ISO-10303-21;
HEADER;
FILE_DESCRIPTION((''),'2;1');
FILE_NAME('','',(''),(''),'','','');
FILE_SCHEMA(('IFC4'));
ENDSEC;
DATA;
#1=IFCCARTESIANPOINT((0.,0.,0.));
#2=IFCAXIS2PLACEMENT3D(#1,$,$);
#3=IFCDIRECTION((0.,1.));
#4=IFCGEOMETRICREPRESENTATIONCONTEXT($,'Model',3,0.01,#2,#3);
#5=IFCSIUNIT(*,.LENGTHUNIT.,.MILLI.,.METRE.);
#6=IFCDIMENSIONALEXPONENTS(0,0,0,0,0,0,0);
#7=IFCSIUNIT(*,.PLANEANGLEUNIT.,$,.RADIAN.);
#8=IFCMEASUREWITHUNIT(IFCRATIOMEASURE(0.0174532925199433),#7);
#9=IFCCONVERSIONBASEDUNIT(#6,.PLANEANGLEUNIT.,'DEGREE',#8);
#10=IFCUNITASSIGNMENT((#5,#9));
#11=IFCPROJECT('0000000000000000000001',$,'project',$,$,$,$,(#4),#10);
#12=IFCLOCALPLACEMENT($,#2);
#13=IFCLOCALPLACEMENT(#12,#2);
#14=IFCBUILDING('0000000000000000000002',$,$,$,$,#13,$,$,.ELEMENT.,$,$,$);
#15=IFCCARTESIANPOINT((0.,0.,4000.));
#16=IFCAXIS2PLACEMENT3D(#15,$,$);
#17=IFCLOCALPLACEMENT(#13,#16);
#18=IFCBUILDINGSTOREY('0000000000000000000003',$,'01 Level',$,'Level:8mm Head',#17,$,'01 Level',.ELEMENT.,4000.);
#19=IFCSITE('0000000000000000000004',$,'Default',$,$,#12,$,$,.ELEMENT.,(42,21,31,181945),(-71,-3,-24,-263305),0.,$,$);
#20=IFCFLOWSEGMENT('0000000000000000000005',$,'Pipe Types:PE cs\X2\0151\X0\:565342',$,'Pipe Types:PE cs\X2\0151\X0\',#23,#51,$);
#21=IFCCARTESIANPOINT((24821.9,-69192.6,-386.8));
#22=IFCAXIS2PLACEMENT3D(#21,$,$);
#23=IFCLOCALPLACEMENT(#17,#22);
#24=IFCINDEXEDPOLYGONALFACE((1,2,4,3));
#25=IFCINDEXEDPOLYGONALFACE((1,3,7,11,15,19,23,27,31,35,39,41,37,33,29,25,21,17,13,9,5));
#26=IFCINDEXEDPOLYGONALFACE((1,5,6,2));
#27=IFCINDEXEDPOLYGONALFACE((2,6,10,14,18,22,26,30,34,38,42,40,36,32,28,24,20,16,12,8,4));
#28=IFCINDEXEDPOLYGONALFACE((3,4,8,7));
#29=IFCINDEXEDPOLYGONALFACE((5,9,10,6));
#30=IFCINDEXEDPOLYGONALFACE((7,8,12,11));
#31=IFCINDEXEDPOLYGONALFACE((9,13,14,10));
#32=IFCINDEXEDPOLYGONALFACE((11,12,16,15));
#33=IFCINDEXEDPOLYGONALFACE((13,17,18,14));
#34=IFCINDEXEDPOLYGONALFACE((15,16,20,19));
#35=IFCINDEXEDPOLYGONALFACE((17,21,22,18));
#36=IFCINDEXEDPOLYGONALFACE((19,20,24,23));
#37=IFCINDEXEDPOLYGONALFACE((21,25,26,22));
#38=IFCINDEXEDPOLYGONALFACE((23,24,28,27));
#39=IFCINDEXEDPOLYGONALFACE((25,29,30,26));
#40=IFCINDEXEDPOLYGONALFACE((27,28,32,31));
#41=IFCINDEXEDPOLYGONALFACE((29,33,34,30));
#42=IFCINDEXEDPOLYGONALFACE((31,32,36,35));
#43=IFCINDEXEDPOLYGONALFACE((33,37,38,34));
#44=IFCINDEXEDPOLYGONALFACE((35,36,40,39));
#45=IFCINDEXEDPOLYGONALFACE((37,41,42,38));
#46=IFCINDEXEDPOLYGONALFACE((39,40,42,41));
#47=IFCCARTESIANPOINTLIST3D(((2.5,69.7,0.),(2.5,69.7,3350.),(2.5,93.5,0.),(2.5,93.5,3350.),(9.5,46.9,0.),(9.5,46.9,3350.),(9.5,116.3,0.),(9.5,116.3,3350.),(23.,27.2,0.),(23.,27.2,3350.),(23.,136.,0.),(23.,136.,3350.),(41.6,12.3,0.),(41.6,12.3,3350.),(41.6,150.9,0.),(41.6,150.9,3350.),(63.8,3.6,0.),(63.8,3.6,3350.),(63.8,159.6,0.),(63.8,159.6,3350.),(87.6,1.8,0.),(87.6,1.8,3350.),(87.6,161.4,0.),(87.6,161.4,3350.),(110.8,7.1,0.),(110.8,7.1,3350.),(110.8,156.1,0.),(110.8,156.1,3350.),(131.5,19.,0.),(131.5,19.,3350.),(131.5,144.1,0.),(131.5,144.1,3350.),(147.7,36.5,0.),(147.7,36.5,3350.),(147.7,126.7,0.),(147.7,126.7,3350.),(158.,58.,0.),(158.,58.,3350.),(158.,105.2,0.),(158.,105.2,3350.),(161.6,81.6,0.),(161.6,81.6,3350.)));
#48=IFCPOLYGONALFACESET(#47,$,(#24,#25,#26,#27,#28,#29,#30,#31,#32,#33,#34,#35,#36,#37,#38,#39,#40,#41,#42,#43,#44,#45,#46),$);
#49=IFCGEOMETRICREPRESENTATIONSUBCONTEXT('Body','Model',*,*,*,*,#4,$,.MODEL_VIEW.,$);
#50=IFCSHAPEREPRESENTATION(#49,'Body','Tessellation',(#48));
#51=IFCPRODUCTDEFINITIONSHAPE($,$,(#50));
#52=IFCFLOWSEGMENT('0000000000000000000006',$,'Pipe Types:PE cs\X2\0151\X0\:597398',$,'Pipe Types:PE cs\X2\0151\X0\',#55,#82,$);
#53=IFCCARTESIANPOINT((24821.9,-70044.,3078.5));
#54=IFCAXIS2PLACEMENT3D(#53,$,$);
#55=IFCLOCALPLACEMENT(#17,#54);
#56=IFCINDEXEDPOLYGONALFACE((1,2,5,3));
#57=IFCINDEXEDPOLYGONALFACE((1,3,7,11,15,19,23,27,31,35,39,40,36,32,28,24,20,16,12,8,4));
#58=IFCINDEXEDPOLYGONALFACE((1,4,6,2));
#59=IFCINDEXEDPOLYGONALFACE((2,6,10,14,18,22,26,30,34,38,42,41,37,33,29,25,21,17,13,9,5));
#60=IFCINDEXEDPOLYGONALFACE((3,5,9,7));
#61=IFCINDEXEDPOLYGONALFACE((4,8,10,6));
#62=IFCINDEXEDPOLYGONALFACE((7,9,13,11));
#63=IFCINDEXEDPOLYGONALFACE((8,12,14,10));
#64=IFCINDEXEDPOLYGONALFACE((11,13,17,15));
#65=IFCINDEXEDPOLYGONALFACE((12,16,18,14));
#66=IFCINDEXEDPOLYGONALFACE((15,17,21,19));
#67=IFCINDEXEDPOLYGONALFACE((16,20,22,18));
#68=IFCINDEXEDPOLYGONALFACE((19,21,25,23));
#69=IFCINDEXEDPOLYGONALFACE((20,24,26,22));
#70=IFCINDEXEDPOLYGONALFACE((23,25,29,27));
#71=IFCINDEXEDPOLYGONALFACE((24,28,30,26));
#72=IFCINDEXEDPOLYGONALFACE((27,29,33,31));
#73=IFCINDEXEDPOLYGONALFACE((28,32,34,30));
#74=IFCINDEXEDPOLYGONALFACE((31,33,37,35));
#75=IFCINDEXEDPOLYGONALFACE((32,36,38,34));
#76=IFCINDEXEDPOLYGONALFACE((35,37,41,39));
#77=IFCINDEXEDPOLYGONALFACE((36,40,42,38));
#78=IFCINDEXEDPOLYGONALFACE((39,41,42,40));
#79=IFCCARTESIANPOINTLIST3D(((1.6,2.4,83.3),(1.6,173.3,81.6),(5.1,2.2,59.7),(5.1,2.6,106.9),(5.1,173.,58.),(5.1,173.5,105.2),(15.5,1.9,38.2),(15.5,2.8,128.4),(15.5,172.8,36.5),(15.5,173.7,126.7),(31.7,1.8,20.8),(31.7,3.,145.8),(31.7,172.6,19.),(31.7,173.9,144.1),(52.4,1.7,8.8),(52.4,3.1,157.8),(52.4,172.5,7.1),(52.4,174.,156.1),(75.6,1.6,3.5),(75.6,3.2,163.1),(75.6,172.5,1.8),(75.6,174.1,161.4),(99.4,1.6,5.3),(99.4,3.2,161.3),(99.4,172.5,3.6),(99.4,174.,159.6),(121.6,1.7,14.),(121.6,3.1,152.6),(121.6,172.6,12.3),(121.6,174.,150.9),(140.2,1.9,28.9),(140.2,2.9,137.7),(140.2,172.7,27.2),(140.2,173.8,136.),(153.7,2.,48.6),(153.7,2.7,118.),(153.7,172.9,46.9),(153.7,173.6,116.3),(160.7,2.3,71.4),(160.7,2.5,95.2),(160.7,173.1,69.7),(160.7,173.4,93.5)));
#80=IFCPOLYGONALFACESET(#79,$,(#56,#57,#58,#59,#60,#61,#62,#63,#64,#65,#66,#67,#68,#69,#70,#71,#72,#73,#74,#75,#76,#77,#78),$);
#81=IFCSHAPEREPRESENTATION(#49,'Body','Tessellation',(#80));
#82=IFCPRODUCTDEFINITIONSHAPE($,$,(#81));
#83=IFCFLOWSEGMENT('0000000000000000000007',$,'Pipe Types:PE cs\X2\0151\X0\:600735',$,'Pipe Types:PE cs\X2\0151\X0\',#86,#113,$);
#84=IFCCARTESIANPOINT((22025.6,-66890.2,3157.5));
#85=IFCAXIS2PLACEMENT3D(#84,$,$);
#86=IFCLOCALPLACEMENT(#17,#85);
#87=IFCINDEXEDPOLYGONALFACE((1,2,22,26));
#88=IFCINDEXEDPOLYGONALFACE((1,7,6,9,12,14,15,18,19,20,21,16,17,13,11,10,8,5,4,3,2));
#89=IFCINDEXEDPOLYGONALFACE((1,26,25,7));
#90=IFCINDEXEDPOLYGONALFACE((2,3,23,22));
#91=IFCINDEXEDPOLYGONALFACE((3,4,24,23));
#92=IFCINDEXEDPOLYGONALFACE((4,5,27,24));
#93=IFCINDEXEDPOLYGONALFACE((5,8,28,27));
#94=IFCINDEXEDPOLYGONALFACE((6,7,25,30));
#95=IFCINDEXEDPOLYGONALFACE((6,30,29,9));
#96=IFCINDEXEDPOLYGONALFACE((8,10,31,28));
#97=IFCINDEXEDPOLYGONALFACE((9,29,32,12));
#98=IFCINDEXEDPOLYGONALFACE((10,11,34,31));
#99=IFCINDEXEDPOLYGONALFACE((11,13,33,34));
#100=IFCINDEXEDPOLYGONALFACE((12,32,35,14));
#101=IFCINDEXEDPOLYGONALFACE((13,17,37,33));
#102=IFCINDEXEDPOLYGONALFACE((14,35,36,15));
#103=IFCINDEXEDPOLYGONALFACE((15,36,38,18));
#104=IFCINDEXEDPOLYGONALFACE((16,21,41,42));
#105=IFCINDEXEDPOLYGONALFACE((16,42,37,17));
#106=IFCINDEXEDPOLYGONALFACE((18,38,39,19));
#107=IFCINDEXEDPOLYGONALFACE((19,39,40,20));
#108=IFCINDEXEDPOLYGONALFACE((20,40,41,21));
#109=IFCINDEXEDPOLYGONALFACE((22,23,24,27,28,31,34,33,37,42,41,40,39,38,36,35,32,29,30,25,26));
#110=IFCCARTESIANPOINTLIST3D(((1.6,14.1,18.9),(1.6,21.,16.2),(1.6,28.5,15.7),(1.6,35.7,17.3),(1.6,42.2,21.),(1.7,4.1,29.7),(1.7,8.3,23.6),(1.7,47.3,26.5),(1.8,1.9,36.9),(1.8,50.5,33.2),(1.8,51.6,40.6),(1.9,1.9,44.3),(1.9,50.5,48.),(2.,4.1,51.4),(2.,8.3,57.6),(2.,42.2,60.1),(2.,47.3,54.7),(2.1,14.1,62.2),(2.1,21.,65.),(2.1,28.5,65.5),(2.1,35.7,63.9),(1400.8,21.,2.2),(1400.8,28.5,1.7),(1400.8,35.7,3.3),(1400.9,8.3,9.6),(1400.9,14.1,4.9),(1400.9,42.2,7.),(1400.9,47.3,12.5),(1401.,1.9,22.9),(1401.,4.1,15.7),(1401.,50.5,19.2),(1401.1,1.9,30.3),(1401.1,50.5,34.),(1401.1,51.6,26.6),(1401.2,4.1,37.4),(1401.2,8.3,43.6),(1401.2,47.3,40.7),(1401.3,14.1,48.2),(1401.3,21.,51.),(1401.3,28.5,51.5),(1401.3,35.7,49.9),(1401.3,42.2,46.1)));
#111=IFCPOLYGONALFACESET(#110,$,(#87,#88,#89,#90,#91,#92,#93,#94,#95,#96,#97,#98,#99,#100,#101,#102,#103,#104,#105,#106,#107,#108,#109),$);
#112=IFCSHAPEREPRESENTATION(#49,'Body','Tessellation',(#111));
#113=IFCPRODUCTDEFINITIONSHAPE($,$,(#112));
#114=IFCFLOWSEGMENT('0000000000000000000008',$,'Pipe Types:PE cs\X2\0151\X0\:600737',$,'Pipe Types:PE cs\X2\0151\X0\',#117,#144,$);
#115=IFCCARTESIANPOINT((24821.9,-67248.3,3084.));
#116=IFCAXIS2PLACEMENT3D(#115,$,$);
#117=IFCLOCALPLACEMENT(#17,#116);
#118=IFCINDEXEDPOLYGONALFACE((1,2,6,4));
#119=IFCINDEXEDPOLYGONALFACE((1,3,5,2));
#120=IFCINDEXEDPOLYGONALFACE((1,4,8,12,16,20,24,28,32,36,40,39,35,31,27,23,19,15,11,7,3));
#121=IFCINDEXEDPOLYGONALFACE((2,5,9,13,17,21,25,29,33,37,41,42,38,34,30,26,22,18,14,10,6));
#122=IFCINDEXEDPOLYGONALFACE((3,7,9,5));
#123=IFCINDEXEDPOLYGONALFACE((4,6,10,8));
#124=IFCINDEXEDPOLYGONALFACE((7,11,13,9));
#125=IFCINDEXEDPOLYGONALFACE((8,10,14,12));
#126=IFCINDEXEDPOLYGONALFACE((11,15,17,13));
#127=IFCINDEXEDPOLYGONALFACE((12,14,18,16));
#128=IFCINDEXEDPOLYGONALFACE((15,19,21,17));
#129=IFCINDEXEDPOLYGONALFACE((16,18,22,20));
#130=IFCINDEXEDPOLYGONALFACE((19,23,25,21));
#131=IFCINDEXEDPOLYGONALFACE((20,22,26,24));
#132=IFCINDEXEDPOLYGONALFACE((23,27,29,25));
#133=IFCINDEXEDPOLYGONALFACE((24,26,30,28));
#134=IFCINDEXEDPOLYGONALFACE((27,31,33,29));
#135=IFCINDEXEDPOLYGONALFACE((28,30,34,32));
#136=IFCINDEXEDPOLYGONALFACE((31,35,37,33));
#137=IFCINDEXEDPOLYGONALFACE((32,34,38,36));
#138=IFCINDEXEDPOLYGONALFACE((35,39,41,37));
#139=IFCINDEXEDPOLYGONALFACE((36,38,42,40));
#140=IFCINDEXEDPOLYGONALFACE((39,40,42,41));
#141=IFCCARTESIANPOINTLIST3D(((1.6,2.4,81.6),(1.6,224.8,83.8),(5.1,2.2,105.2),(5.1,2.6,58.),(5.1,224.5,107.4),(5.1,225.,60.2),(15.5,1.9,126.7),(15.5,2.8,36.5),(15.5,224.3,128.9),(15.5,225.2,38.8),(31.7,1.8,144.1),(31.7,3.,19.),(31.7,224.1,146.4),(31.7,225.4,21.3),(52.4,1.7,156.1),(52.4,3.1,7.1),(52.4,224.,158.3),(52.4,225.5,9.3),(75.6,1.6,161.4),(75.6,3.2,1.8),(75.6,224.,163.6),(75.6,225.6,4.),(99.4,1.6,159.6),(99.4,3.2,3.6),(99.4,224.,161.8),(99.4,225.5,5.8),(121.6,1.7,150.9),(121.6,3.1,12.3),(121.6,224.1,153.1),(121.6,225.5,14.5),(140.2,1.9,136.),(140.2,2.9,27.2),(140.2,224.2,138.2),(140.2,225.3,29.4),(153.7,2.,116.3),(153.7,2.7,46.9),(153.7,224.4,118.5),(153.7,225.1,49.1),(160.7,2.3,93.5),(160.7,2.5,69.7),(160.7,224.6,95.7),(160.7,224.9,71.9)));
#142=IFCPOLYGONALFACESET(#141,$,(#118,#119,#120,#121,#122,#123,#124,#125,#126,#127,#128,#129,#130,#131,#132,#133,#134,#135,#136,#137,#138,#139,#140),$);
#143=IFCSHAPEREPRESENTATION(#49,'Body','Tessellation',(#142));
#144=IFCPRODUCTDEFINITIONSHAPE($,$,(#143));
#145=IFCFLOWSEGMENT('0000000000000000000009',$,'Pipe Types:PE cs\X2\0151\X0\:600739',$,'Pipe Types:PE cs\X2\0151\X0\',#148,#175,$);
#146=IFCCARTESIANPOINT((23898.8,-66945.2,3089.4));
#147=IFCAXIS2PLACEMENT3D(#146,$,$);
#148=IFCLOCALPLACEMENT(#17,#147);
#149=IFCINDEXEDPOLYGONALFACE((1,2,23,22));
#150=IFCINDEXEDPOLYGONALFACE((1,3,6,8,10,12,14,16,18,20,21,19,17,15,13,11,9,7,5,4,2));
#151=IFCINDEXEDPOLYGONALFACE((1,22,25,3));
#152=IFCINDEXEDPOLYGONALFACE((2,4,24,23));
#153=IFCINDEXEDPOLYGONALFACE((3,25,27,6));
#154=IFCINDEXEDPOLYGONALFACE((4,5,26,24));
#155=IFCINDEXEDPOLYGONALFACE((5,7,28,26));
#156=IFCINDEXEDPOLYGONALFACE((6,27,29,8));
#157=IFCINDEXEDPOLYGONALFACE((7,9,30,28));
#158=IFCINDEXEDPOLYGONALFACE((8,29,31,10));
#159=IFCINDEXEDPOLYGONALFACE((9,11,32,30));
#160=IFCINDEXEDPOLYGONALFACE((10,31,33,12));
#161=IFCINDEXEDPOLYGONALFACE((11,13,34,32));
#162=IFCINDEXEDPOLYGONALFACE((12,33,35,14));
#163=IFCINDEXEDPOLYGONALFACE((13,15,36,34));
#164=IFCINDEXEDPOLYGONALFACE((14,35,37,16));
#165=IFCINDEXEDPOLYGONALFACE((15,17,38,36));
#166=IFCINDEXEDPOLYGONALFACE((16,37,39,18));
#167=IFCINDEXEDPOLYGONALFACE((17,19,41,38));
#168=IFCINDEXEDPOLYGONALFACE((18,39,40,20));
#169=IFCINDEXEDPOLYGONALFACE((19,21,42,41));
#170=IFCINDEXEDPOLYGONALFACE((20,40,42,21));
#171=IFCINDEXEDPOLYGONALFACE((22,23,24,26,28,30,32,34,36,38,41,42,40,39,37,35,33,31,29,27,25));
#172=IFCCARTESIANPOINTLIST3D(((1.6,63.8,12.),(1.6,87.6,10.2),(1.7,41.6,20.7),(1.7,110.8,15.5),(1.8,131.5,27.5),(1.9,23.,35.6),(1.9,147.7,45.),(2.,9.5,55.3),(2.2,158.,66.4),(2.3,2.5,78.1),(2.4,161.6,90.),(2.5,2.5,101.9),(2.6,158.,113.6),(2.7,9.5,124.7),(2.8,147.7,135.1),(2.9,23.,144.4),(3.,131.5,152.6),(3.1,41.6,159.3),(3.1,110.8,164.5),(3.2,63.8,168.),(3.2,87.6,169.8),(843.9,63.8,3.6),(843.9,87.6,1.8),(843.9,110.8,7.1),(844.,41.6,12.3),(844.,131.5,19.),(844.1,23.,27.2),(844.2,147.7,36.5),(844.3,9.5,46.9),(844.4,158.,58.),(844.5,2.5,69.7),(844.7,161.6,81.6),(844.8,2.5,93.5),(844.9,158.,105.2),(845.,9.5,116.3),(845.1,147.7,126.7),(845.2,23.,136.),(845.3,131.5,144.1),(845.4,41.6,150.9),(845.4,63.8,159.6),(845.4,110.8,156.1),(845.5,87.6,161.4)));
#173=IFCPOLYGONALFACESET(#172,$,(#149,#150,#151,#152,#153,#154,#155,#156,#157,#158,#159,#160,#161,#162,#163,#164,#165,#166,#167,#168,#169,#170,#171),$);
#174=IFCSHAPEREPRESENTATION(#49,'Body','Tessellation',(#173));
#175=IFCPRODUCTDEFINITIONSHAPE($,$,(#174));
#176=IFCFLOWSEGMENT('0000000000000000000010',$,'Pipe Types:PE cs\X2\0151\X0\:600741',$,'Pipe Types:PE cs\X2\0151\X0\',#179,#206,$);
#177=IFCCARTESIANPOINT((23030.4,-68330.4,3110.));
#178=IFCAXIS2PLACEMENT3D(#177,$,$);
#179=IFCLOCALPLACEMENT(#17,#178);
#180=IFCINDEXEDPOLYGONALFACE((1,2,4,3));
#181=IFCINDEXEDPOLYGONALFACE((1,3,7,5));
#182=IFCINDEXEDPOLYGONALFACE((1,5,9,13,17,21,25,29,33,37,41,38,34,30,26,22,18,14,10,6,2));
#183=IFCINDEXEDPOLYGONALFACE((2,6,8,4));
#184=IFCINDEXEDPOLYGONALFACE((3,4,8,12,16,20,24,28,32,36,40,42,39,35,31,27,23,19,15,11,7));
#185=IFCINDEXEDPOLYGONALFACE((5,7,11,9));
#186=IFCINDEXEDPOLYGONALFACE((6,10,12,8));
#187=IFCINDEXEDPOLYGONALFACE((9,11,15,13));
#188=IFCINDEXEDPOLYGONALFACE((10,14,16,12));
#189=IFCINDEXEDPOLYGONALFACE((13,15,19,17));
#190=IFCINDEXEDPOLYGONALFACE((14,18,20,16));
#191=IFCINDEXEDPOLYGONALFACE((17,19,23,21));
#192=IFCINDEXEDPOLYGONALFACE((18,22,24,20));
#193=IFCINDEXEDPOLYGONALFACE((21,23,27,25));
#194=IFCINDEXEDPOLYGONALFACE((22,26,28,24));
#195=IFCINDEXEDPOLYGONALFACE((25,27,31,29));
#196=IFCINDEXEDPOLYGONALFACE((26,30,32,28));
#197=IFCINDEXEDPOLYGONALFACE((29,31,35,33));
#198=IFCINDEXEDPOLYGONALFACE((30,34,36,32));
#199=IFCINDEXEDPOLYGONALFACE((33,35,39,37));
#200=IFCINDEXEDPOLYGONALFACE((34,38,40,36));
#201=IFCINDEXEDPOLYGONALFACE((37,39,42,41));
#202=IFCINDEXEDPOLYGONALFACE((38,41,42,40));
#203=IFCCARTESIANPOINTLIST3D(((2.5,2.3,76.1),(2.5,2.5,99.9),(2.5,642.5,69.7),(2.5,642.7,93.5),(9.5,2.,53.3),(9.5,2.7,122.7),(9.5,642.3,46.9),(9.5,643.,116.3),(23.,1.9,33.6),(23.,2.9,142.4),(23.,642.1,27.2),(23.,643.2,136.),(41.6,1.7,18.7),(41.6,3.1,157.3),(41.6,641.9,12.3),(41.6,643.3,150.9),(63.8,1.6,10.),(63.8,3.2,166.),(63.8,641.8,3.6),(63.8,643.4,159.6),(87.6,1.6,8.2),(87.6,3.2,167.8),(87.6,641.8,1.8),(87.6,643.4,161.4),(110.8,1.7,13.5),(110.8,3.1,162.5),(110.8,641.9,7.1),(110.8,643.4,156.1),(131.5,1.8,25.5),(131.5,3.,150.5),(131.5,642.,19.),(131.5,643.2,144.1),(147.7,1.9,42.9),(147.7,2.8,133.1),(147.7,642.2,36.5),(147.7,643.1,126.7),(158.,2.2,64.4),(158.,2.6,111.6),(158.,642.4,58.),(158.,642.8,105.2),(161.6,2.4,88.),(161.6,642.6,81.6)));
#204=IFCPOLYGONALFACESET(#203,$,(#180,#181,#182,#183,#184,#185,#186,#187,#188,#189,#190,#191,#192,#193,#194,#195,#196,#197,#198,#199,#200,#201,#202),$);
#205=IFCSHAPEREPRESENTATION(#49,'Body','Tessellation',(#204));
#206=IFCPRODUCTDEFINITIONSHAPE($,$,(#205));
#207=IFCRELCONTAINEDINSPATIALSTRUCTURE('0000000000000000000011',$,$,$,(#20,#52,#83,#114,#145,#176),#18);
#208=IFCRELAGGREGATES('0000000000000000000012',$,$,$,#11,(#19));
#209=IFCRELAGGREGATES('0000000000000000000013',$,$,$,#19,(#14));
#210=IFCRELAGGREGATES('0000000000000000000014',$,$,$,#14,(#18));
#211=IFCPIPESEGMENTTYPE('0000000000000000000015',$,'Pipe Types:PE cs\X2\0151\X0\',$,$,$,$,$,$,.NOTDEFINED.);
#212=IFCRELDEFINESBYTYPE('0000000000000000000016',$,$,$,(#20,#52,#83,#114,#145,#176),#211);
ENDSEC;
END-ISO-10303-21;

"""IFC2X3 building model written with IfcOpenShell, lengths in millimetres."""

from ifc_helpers import new_model, entity, si_unit, converted_unit, direction, frame, frame_2d, origin, origin_2d_with_axis, place, context, subcontext, project, spatial, circle, extrude, type_object, element, save


model = new_model("IFC2X3")

# Units and contexts
model_context = context("Model", 3, precision=0.01, world=origin(), true_north=direction((0.0, 1.0)))
body_context = subcontext(model_context, "Body", "Model", "MODEL_VIEW")
ifc_project = project(units=[si_unit("LENGTHUNIT", "METRE", prefix="MILLI"), converted_unit("PLANEANGLEUNIT", "DEGREE", entity("IfcRatioMeasure", 0.0174532925199433), si_unit("PLANEANGLEUNIT", "RADIAN"), dimensions=[0, 0, 0, 0, 0, 0, 0])], contexts=[model_context])

# Site, building, storey
site_placement = place(None, origin())
site = spatial("IfcSite", under=ifc_project, at=site_placement, Name="Default", CompositionType="ELEMENT", RefLatitude=(42, 21, 31, 181945), RefLongitude=(-71, -3, -24, -263305), RefElevation=0.0)
building_placement = place(site_placement, origin())
building = spatial("IfcBuilding", under=site, at=building_placement, CompositionType="ELEMENT")
storey_placement = place(building_placement, frame((0.0, 0.0, 4000.0)))
storey = spatial("IfcBuildingStorey", under=building, at=storey_placement, Name="01 Level", ObjectType="Level:8mm Head", LongName="01 Level", CompositionType="ELEMENT", Elevation=4000.0)

# Flow segments
pipe_segment_type = type_object("IfcPipeSegmentType", Name="Pipe Types:PE cső", PredefinedType="NOTDEFINED")
flow_segment_1_placement = place(storey_placement, frame((24821.9, -69192.6, -386.8)))
element("IfcFlowSegment", 1, at=flow_segment_1_placement, inside=storey, type_object=pipe_segment_type, Name="Pipe Types:PE cső:565342", ObjectType="Pipe Types:PE cső", context=body_context, shape_type="SweptSolid", body=[
    extrude(circle(Radius=80.0, at=origin_2d_with_axis()), frame((81.6, 81.6, 0.0)), (0.0, 0.0, 1.0), 3350.0),
])
flow_segment_2_placement = place(storey_placement, frame((24821.9, -70044.0, 3078.5)))
element("IfcFlowSegment", 2, at=flow_segment_2_placement, inside=storey, type_object=pipe_segment_type, Name="Pipe Types:PE cső:597398", ObjectType="Pipe Types:PE cső", context=body_context, shape_type="SweptSolid", body=[
    extrude(circle(Radius=80.0, at=origin_2d_with_axis()), frame((81.6, 2.4, 83.3), z_axis=(0.0, 0.99995, -0.01), x_axis=(-1.0, 0.0, 0.0)), (0.0, 0.0, 1.0), 170.9),
])
flow_segment_3_placement = place(storey_placement, frame((22025.6, -66890.2, 3157.5)))
element("IfcFlowSegment", 3, at=flow_segment_3_placement, inside=storey, type_object=pipe_segment_type, Name="Pipe Types:PE cső:600735", ObjectType="Pipe Types:PE cső", context=body_context, shape_type="SweptSolid", body=[
    extrude(circle(Radius=25.0, at=frame_2d((0.0, 0.0), x_axis=(1.0, 0.0))), frame((1.8, 26.6, 40.6), z_axis=(0.99995, 0.0, -0.01), x_axis=(0.0, 1.0, 0.0)), (0.0, 0.0, 1.0), 1399.3),
])
flow_segment_4_placement = place(storey_placement, frame((24821.9, -67248.3, 3084.0)))
element("IfcFlowSegment", 4, at=flow_segment_4_placement, inside=storey, type_object=pipe_segment_type, Name="Pipe Types:PE cső:600737", ObjectType="Pipe Types:PE cső", context=body_context, shape_type="SweptSolid", body=[
    extrude(circle(Radius=80.0, at=origin_2d_with_axis()), frame((81.6, 2.4, 81.6), z_axis=(0.0, 0.99995, 0.01), x_axis=(-1.0, 0.0, 0.0)), (0.0, 0.0, 1.0), 222.4),
])
flow_segment_5_placement = place(storey_placement, frame((23898.8, -66945.2, 3089.4)))
element("IfcFlowSegment", 5, at=flow_segment_5_placement, inside=storey, type_object=pipe_segment_type, Name="Pipe Types:PE cső:600739", ObjectType="Pipe Types:PE cső", context=body_context, shape_type="SweptSolid", body=[
    extrude(circle(Radius=80.0, at=origin_2d_with_axis()), frame((844.7, 81.6, 81.6), z_axis=(-0.99995, 0.0, 0.01), x_axis=(0.0, 1.0, 0.0)), (0.0, 0.0, 1.0), 842.3),
])
flow_segment_6_placement = place(storey_placement, frame((23030.4, -68330.4, 3110.0)))
element("IfcFlowSegment", 6, at=flow_segment_6_placement, inside=storey, type_object=pipe_segment_type, Name="Pipe Types:PE cső:600741", ObjectType="Pipe Types:PE cső", context=body_context, shape_type="SweptSolid", body=[
    extrude(circle(Radius=80.0, at=frame_2d((0.0, 0.0), x_axis=(1.0, 0.0))), frame((81.6, 2.4, 88.0), z_axis=(0.0, 0.99995, -0.01), x_axis=(1.0, 0.0, 0.0)), (0.0, 0.0, 1.0), 640.2),
])

save(model, "model.ifc")
